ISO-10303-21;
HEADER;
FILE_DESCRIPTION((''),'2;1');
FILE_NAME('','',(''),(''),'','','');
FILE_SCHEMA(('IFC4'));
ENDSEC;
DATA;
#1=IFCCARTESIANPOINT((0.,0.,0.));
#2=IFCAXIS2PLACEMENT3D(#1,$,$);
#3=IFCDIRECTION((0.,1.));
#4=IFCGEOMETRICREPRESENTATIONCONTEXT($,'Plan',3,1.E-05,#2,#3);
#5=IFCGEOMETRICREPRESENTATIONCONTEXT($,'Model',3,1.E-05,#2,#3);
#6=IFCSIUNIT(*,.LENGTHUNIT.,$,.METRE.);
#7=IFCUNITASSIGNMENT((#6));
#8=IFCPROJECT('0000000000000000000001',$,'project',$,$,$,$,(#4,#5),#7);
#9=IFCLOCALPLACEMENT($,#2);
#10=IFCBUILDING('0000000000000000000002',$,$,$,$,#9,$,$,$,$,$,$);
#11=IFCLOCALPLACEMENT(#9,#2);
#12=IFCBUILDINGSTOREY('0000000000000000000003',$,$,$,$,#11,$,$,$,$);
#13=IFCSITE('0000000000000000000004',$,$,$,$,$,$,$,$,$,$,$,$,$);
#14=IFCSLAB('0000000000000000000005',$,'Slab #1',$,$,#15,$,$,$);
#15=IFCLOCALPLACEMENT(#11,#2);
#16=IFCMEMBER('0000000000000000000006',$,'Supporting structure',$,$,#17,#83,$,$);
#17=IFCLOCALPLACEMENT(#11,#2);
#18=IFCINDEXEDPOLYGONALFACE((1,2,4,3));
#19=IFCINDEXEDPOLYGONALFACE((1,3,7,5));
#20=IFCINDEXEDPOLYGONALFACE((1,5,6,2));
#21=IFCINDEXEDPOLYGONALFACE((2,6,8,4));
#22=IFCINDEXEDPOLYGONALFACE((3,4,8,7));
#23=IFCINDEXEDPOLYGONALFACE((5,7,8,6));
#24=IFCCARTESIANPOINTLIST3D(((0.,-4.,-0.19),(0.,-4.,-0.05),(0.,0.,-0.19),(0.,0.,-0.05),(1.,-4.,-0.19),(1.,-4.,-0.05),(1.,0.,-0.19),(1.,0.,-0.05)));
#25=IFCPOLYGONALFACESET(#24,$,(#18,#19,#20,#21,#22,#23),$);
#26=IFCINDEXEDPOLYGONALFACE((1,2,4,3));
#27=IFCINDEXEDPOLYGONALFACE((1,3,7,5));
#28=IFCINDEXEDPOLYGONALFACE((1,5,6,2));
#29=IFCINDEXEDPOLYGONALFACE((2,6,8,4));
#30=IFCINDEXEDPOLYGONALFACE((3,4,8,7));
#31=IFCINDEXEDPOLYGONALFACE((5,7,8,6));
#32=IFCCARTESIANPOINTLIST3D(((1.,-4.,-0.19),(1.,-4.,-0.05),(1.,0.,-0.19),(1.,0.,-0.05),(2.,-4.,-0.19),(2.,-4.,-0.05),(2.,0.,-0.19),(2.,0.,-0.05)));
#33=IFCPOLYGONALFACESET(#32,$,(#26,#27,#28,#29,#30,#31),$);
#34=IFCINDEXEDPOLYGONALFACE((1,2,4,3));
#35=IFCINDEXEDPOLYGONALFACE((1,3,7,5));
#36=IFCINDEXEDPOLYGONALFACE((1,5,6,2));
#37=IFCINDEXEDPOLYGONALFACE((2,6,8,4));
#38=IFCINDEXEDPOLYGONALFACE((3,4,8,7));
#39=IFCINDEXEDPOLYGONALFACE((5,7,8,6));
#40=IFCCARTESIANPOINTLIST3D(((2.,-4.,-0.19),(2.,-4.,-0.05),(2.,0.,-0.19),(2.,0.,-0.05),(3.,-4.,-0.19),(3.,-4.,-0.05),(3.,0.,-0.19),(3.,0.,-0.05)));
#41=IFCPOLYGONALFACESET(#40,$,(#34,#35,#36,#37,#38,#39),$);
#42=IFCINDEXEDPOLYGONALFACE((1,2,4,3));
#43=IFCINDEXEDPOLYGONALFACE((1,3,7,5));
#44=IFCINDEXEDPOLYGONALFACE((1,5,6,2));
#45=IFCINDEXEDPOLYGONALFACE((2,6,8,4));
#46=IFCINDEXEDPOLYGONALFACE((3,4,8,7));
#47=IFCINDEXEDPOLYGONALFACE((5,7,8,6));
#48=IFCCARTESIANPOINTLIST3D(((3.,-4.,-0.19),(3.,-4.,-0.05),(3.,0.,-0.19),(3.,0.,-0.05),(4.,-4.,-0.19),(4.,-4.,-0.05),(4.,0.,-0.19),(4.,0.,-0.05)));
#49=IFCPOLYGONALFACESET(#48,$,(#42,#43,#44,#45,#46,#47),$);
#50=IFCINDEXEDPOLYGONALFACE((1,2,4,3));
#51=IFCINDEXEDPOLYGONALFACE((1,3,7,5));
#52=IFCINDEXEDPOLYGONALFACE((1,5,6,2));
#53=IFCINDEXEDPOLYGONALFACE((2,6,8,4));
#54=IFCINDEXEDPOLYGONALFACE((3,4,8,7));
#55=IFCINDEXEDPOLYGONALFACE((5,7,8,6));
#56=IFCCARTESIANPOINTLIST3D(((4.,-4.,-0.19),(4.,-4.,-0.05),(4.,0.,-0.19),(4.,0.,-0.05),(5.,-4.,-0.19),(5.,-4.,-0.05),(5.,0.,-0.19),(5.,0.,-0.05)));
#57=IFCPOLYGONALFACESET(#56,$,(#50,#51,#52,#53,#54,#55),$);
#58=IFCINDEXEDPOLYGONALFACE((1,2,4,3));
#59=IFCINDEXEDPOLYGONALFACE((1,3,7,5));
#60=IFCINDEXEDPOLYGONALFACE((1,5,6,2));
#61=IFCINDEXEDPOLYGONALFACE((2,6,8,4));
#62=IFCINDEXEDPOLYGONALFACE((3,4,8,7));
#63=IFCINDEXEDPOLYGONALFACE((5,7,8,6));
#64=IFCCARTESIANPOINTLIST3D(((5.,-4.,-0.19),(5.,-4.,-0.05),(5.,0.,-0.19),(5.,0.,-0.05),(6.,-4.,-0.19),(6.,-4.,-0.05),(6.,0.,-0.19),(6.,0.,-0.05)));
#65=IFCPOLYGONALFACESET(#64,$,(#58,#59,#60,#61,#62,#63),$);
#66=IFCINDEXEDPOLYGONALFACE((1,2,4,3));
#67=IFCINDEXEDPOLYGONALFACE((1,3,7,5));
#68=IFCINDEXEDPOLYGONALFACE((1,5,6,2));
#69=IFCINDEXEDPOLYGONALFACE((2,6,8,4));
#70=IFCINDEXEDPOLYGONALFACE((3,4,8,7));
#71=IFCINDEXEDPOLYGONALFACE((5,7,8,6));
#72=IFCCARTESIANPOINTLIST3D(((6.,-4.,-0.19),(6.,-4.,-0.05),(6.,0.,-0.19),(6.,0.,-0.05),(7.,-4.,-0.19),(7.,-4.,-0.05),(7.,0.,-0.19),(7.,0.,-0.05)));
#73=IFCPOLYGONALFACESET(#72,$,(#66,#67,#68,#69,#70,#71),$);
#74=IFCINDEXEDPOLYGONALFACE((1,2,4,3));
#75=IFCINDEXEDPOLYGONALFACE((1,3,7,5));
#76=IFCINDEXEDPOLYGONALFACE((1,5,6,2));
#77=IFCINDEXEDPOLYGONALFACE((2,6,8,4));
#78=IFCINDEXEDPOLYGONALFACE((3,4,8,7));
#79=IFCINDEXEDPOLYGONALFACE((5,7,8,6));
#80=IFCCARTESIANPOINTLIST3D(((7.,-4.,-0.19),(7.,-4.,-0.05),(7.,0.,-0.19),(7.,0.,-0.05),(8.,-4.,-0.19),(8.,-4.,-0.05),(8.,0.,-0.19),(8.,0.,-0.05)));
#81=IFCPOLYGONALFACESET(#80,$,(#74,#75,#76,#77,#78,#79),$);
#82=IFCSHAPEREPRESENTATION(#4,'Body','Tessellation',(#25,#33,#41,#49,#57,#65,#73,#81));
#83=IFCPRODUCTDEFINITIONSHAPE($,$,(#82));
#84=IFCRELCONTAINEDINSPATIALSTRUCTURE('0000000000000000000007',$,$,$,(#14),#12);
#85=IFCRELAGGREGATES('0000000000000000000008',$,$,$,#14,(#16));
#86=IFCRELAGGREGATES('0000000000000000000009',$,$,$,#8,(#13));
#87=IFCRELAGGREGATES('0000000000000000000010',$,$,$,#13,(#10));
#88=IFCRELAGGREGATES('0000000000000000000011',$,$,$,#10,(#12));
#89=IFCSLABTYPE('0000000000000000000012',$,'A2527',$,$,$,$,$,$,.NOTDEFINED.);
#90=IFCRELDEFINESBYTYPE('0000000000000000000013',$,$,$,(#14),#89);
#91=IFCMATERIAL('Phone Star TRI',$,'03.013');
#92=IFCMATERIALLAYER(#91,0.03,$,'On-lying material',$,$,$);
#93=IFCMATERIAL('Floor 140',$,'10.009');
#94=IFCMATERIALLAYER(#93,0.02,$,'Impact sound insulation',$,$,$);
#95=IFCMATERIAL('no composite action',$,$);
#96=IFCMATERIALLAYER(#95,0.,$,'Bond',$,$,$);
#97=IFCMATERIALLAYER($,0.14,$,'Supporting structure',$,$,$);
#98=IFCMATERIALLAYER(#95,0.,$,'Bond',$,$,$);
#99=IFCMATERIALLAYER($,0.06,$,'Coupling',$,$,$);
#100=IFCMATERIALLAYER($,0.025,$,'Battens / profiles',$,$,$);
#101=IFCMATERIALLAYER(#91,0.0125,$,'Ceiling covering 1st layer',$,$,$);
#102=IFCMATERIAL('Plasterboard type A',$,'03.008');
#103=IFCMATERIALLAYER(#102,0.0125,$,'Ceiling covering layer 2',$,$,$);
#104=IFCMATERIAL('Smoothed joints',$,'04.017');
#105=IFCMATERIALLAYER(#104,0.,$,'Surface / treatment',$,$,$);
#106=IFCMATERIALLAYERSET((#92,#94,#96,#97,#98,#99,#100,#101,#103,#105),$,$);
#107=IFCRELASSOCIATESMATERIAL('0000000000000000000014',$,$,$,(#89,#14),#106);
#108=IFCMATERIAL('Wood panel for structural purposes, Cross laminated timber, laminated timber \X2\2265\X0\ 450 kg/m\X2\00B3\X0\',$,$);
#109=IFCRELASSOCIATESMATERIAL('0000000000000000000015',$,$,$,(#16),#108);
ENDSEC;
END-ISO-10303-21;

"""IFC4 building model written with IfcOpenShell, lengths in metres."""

from ifc_helpers import new_model, si_unit, direction, frame, frame_2d, origin, place, context, project, spatial, rectangle, extrude, material, layer, layer_set, type_object, element, aggregate, save


model = new_model("IFC4")

# Units and contexts
plan_context = context("Plan", 3, precision=1e-05, world=origin(), true_north=direction((0.0, 1.0)))
model_context = context("Model", 3, precision=1e-05, world=origin(), true_north=direction((0.0, 1.0)))
ifc_project = project(units=[si_unit("LENGTHUNIT", "METRE")], contexts=[plan_context, model_context])

# Site, building, storey
site = spatial("IfcSite", under=ifc_project)
building_placement = place(None, origin())
building = spatial("IfcBuilding", under=site, at=building_placement)
storey_placement = place(building_placement, origin())
storey = spatial("IfcBuildingStorey", under=building, at=storey_placement)

# Slab, member
ifc_material_1 = material(Name="Phone Star TRI", Category="03.013")
ifc_layer_1 = layer(ifc_material_1, 0.03, Name="On-lying material")
ifc_material_2 = material(Name="Floor 140", Category="10.009")
ifc_layer_2 = layer(ifc_material_2, 0.02, Name="Impact sound insulation")
ifc_material_3 = material(Name="no composite action")
ifc_layer_3 = layer(ifc_material_3, 0.0, Name="Bond")
ifc_layer_4 = layer(None, 0.14, Name="Supporting structure")
ifc_layer_5 = layer(ifc_material_3, 0.0, Name="Bond")
ifc_layer_6 = layer(None, 0.06, Name="Coupling")
ifc_layer_7 = layer(None, 0.025, Name="Battens / profiles")
ifc_layer_8 = layer(ifc_material_1, 0.0125, Name="Ceiling covering 1st layer")
ifc_material_4 = material(Name="Plasterboard type A", Category="03.008")
ifc_layer_9 = layer(ifc_material_4, 0.0125, Name="Ceiling covering layer 2")
ifc_material_5 = material(Name="Smoothed joints", Category="04.017")
ifc_layer_10 = layer(ifc_material_5, 0.0, Name="Surface / treatment")
ifc_layer_set = layer_set([ifc_layer_1, ifc_layer_2, ifc_layer_3, ifc_layer_4, ifc_layer_5, ifc_layer_6, ifc_layer_7, ifc_layer_8, ifc_layer_9, ifc_layer_10])
slab_type = type_object("IfcSlabType", Name="A2527", PredefinedType="NOTDEFINED", material=ifc_layer_set)
slab_placement = place(None, frame((0.0, 0.0, 0.0), z_axis=(0.0, 0.0, -1.0), x_axis=(1.0, 0.0, 0.0)))
slab = element("IfcSlab", 1, at=slab_placement, inside=storey, type_object=slab_type, material=ifc_layer_set, Name="Slab #1")
ifc_material_6 = material(Name="Wood panel for structural purposes, Cross laminated timber, laminated timber ≥ 450 kg/m³")
member_1_placement = place(slab_placement, origin())
member_1 = element("IfcMember", 2, at=member_1_placement, material=ifc_material_6, Name="Supporting structure", context=plan_context, shape_type="SweptSolid", body=[
    extrude(rectangle(XDim=1.0, YDim=0.14, at=frame_2d((0.5, 0.07), x_axis=(1.0, 0.0))), frame((0.0, 4.0, 0.05), z_axis=(0.0, -1.0, 0.0), x_axis=(1.0, 0.0, 0.0)), (0.0, 0.0, 1.0), 4.0),
    extrude(rectangle(XDim=1.0, YDim=0.14, at=frame_2d((0.5, 0.07), x_axis=(1.0, 0.0))), frame((1.0, 4.0, 0.05), z_axis=(0.0, -1.0, 0.0), x_axis=(1.0, 0.0, 0.0)), (0.0, 0.0, 1.0), 4.0),
    extrude(rectangle(XDim=1.0, YDim=0.14, at=frame_2d((0.5, 0.07), x_axis=(1.0, 0.0))), frame((2.0, 4.0, 0.05), z_axis=(0.0, -1.0, 0.0), x_axis=(1.0, 0.0, 0.0)), (0.0, 0.0, 1.0), 4.0),
    extrude(rectangle(XDim=1.0, YDim=0.14, at=frame_2d((0.5, 0.07), x_axis=(1.0, 0.0))), frame((3.0, 4.0, 0.05), z_axis=(0.0, -1.0, 0.0), x_axis=(1.0, 0.0, 0.0)), (0.0, 0.0, 1.0), 4.0),
    extrude(rectangle(XDim=1.0, YDim=0.14, at=frame_2d((0.5, 0.07), x_axis=(1.0, 0.0))), frame((4.0, 4.0, 0.05), z_axis=(0.0, -1.0, 0.0), x_axis=(1.0, 0.0, 0.0)), (0.0, 0.0, 1.0), 4.0),
    extrude(rectangle(XDim=1.0, YDim=0.14, at=frame_2d((0.5, 0.07), x_axis=(1.0, 0.0))), frame((5.0, 4.0, 0.05), z_axis=(0.0, -1.0, 0.0), x_axis=(1.0, 0.0, 0.0)), (0.0, 0.0, 1.0), 4.0),
    extrude(rectangle(XDim=1.0, YDim=0.14, at=frame_2d((0.5, 0.07), x_axis=(1.0, 0.0))), frame((6.0, 4.0, 0.05), z_axis=(0.0, -1.0, 0.0), x_axis=(1.0, 0.0, 0.0)), (0.0, 0.0, 1.0), 4.0),
    extrude(rectangle(XDim=1.0, YDim=0.14, at=frame_2d((0.5, 0.07), x_axis=(1.0, 0.0))), frame((7.0, 4.0, 0.05), z_axis=(0.0, -1.0, 0.0), x_axis=(1.0, 0.0, 0.0)), (0.0, 0.0, 1.0), 4.0),
])
aggregate(slab, [member_1])

save(model, "model.ifc")
